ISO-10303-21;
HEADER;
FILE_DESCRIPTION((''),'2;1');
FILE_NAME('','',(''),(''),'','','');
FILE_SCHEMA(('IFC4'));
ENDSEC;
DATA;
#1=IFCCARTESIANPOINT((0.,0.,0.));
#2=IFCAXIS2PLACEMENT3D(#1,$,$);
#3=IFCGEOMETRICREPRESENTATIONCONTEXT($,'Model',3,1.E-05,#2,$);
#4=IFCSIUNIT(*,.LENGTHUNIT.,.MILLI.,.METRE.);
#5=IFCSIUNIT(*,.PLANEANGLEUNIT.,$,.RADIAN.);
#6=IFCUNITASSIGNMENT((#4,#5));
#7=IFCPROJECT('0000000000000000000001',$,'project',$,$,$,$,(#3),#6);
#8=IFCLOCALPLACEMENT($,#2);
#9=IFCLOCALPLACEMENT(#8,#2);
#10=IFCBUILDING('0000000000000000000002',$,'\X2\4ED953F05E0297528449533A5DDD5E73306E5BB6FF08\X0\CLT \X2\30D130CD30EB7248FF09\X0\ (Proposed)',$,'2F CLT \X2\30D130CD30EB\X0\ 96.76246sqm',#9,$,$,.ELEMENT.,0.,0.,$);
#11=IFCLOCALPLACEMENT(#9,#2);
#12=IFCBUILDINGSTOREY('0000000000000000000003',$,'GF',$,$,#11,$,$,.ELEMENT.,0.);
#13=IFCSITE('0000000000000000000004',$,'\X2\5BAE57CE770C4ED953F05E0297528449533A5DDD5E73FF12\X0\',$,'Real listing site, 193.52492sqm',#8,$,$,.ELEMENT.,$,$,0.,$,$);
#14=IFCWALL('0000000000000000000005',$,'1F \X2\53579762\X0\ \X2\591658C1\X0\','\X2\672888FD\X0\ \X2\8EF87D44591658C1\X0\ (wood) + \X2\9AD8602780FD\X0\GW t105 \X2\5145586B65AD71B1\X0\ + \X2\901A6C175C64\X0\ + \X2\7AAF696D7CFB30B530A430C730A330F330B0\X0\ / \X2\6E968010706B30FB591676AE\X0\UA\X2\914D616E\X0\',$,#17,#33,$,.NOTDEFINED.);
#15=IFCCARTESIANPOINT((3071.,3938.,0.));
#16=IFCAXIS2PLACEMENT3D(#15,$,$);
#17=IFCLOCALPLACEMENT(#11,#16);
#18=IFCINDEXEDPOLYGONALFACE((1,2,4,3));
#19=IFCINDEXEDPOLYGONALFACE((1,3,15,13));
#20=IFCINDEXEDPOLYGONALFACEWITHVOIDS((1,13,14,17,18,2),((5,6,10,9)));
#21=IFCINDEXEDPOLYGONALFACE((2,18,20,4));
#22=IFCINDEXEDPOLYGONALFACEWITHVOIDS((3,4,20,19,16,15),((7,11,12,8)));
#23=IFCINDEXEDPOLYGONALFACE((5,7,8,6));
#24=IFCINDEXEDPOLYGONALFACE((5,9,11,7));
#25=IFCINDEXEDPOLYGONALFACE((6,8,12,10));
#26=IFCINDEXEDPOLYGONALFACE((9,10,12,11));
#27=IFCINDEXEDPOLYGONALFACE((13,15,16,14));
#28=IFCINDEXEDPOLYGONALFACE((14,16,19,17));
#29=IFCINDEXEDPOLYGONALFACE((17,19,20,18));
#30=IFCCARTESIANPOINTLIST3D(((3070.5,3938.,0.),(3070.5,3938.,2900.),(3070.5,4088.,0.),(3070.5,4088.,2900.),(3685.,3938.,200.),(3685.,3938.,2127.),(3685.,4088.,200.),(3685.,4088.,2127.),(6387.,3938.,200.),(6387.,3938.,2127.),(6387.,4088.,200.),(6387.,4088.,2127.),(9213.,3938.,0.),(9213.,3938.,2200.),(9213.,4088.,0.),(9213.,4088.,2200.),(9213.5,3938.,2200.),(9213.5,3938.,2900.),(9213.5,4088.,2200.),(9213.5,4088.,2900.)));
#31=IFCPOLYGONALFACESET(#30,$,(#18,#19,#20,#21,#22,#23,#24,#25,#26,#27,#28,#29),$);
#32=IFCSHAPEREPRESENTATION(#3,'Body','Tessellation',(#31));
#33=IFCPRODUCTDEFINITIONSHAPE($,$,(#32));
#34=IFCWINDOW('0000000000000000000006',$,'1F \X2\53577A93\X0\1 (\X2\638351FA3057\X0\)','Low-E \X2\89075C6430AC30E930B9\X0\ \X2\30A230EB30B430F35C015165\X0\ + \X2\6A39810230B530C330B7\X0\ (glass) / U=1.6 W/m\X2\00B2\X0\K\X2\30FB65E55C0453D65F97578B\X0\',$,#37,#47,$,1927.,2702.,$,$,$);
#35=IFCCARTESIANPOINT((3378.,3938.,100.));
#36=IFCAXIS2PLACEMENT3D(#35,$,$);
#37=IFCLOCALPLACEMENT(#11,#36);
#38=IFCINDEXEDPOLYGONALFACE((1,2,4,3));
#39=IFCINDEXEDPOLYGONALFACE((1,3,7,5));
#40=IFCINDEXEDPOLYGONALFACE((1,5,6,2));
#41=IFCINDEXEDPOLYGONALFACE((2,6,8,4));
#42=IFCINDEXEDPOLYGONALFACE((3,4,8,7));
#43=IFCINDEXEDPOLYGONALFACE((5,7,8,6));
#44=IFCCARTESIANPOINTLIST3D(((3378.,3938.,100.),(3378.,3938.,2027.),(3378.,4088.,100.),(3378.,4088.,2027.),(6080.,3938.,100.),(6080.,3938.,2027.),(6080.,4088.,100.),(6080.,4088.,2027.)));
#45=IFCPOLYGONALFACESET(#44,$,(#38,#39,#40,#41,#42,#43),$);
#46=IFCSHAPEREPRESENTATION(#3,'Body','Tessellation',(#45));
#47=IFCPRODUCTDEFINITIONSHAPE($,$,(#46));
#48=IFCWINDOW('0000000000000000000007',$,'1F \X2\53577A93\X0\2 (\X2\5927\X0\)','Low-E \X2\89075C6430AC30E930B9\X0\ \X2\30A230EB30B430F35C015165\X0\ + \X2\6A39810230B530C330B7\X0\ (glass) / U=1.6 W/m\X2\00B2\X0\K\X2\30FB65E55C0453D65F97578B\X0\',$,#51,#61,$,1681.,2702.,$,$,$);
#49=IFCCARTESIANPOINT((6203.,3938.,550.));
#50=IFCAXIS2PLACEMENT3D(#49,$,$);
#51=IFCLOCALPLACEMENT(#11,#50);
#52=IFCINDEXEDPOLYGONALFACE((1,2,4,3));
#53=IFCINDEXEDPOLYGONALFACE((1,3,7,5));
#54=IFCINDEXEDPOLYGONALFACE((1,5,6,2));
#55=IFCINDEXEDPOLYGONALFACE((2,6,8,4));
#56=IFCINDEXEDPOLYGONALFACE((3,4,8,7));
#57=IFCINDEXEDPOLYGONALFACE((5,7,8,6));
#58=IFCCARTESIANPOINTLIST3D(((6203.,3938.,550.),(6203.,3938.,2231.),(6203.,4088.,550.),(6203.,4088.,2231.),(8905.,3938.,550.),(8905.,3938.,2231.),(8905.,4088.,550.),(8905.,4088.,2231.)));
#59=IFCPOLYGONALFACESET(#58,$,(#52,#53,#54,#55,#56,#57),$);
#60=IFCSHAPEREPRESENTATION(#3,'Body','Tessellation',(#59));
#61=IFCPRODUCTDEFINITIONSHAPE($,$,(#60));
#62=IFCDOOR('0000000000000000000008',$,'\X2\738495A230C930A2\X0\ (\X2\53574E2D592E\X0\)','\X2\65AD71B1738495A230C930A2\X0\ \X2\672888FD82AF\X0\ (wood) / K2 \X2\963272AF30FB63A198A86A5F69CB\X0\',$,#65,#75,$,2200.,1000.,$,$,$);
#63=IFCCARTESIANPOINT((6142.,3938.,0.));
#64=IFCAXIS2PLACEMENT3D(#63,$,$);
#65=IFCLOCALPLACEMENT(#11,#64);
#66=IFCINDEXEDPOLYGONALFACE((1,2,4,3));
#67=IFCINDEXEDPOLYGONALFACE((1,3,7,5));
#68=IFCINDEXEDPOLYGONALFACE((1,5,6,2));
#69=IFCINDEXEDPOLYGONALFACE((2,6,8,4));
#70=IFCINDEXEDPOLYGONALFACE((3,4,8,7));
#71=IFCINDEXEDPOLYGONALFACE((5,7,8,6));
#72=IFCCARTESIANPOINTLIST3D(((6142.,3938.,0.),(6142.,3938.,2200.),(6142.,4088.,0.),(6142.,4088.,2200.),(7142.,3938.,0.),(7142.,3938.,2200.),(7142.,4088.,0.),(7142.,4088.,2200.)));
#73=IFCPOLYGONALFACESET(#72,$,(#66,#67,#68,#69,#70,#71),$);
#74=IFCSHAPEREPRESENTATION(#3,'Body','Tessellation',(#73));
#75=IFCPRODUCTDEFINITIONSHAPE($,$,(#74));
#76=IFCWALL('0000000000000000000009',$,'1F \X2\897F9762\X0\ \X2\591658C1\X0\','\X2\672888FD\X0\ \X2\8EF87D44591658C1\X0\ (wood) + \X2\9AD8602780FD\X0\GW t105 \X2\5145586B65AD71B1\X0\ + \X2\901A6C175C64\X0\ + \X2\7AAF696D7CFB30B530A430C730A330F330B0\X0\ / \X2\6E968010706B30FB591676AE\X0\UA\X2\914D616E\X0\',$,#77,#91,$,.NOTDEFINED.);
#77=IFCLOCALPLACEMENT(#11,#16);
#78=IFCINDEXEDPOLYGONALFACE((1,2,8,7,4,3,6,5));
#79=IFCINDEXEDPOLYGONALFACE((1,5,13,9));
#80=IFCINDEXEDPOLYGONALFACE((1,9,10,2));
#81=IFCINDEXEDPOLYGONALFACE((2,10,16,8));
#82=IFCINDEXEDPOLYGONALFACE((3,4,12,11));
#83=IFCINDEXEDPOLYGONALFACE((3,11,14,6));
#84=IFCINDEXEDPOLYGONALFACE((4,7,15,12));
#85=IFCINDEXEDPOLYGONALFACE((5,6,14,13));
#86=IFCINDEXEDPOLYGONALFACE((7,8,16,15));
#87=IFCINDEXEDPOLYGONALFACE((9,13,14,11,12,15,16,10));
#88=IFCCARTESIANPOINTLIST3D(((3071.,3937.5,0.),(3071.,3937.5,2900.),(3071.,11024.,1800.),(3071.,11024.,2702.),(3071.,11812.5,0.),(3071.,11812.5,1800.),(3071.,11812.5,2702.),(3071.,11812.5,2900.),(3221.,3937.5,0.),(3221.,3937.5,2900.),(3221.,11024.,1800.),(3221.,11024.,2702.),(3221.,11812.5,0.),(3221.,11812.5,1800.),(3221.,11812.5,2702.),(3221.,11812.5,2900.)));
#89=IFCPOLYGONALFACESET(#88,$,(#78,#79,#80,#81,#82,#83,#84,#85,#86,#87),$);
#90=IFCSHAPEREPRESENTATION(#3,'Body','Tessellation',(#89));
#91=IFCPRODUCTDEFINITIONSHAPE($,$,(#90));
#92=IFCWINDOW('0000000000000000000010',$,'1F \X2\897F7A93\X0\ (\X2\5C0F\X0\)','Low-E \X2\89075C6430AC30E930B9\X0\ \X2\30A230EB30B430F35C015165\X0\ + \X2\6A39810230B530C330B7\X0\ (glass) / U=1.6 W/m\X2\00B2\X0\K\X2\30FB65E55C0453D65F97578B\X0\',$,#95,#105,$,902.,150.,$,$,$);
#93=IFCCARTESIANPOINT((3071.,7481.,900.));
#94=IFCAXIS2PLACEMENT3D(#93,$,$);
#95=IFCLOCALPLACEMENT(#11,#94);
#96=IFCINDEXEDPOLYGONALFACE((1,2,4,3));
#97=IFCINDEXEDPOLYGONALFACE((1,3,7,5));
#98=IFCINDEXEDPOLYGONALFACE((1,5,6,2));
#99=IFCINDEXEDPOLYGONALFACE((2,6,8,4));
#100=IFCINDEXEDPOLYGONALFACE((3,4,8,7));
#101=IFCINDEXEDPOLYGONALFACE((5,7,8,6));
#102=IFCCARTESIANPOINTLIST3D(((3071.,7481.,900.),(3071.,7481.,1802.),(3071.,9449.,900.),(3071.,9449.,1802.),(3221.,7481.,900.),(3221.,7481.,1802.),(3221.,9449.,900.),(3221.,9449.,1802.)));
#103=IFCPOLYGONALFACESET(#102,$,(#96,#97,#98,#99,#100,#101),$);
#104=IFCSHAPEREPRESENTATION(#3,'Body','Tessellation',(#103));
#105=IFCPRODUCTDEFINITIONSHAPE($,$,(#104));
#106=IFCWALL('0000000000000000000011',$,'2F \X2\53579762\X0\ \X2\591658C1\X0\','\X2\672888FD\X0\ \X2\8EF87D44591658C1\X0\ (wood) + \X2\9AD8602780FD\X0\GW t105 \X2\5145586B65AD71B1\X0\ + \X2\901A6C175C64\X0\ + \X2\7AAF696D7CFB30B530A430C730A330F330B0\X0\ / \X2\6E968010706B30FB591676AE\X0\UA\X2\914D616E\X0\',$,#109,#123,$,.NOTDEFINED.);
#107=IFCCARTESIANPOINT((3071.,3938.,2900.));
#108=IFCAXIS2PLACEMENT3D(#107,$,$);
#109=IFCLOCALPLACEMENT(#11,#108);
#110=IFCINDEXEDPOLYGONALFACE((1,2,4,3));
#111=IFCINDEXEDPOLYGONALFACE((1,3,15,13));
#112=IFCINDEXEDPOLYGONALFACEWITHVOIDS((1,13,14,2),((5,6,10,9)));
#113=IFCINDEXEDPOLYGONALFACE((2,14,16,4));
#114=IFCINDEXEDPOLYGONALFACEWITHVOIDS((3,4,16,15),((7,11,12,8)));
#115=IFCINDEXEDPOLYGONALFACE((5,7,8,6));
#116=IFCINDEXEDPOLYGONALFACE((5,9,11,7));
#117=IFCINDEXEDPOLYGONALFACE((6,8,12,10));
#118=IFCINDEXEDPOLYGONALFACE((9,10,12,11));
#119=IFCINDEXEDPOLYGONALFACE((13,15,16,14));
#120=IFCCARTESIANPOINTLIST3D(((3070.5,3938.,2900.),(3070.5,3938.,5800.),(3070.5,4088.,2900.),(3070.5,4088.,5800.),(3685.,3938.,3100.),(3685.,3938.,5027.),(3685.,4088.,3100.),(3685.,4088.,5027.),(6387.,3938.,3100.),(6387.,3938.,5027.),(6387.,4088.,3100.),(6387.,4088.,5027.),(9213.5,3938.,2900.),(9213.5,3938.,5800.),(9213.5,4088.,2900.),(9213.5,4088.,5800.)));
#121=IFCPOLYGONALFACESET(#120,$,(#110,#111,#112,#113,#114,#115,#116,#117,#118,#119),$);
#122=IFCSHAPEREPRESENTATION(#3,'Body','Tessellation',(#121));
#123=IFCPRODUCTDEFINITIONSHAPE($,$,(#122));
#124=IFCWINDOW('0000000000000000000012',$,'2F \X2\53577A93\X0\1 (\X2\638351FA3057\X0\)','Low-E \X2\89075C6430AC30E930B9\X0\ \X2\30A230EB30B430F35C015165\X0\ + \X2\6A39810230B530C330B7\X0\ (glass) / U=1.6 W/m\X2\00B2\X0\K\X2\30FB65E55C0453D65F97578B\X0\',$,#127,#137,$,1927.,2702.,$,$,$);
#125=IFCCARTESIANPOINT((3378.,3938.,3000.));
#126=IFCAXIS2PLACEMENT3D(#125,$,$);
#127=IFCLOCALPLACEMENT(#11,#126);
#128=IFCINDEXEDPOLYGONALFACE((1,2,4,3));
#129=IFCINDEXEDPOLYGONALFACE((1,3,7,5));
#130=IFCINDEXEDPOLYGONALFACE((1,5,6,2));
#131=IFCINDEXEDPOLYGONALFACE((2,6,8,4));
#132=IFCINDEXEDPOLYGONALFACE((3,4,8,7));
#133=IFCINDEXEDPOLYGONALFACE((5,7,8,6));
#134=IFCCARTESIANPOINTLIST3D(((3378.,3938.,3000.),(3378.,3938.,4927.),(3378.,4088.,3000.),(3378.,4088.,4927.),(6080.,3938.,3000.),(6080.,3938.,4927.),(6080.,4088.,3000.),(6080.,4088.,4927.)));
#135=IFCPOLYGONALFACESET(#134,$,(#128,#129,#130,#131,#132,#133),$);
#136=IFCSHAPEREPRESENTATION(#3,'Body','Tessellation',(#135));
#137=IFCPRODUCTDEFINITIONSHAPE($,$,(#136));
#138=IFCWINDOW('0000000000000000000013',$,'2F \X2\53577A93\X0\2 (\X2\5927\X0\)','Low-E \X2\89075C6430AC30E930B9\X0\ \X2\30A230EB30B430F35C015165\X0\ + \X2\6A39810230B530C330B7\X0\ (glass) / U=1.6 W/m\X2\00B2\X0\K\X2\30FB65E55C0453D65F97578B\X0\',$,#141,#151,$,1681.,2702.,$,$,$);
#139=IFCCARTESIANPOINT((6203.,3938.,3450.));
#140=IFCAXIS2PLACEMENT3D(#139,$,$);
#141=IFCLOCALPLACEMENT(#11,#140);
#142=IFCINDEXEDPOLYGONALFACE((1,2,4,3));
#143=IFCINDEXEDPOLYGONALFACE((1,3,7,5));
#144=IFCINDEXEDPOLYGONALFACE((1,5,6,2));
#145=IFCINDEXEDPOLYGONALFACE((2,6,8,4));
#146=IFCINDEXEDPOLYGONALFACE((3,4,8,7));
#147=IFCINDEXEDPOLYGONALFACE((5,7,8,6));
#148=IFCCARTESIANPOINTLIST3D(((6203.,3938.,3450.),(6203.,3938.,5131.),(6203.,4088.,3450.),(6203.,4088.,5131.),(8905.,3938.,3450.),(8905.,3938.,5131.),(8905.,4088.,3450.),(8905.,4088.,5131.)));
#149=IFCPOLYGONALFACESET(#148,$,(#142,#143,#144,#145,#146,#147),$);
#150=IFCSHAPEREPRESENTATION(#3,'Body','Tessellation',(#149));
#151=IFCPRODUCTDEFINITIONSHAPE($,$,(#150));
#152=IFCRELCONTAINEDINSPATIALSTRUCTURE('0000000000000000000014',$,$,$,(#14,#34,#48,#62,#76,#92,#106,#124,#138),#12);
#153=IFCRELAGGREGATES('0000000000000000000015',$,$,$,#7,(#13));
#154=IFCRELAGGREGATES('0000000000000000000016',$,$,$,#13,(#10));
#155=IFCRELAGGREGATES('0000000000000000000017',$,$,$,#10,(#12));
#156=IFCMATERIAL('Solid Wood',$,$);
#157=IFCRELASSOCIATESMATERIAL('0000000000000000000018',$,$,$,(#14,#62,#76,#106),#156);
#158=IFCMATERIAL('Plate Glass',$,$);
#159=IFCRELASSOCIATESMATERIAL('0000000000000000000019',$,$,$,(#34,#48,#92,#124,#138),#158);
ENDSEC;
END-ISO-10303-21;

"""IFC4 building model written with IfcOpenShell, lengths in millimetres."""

from ifc_helpers import new_model, si_unit, frame, frame_2d, origin, place, context, project, spatial, rectangle, extrude, material, element, fill, save


model = new_model("IFC4")

# Units and contexts
model_context = context("Model", 3, precision=1e-05, world=origin())
ifc_project = project(units=[si_unit("LENGTHUNIT", "METRE", prefix="MILLI"), si_unit("PLANEANGLEUNIT", "RADIAN")], contexts=[model_context])

# Site, building, storey
site_placement = place(None, origin())
site = spatial("IfcSite", under=ifc_project, at=site_placement, Name="宮城県仙台市青葉区川平２", ObjectType="Real listing site, 193.52492sqm", CompositionType="ELEMENT", RefElevation=0.0)
building_placement = place(site_placement, origin())
building = spatial("IfcBuilding", under=site, at=building_placement, Name="仙台市青葉区川平の家（CLT パネル版） (Proposed)", ObjectType="2F CLT パネル 96.76246sqm", CompositionType="ELEMENT", ElevationOfRefHeight=0.0, ElevationOfTerrain=0.0)
storey_placement = place(building_placement, origin())
storey = spatial("IfcBuildingStorey", under=building, at=storey_placement, Name="GF", CompositionType="ELEMENT", Elevation=0.0)

# Shared definitions
ifc_material_1 = material(Name="Solid Wood")

# Wall, openings, windows, door
wall_1_placement = place(storey_placement, frame((3071.0, 3938.0, 0.0)))
wall_1 = element("IfcWall", 1, at=wall_1_placement, inside=storey, material=ifc_material_1, Name="1F 南面 外壁", Description="木製 軸組外壁 (wood) + 高性能GW t105 充填断熱 + 通気層 + 窯業系サイディング / 準耐火・外皮UA配慮", PredefinedType="NOTDEFINED", context=model_context, shape_type="SweptSolid", body=[
    extrude(rectangle(XDim=6143.0, YDim=150.0, at=frame_2d((3071.0, 75.0))), frame((3071.0, 3938.0, 0.0)), (0.0, 0.0, 1.0), 2900.0),
])
opening_1_placement = place(storey_placement, frame((3378.0, 3938.0, 100.0)))
opening_1 = element("IfcOpeningElement", 2, at=opening_1_placement, cuts=wall_1, PredefinedType="NOTDEFINED", context=model_context, shape_type="SweptSolid", body=[
    extrude(rectangle(XDim=2702.0, YDim=150.0, at=frame_2d((1351.0, 75.0))), frame((3378.0, 3938.0, 100.0)), (0.0, 0.0, 1.0), 1927.0),
])
opening_2_placement = place(storey_placement, frame((6203.0, 3938.0, 550.0)))
opening_2 = element("IfcOpeningElement", 3, at=opening_2_placement, cuts=wall_1, PredefinedType="NOTDEFINED", context=model_context, shape_type="SweptSolid", body=[
    extrude(rectangle(XDim=2702.0, YDim=150.0, at=frame_2d((1351.0, 75.0))), frame((6203.0, 3938.0, 550.0)), (0.0, 0.0, 1.0), 1681.0),
])
opening_3_placement = place(storey_placement, frame((6142.0, 3938.0, 0.0)))
opening_3 = element("IfcOpeningElement", 4, at=opening_3_placement, cuts=wall_1, PredefinedType="NOTDEFINED", context=model_context, shape_type="SweptSolid", body=[
    extrude(rectangle(XDim=1000.0, YDim=150.0, at=frame_2d((500.0, 75.0))), frame((6142.0, 3938.0, 0.0)), (0.0, 0.0, 1.0), 2200.0),
])
ifc_material_2 = material(Name="Plate Glass")
window_1_placement = place(storey_placement, frame((3378.0, 3938.0, 100.0)))
window_1 = element("IfcWindow", 5, at=window_1_placement, inside=storey, material=ifc_material_2, Name="1F 南窓1 (掃出し)", Description="Low-E 複層ガラス アルゴン封入 + 樹脂サッシ (glass) / U=1.6 W/m²K・日射取得型", OverallHeight=1927.0, OverallWidth=2702.0, context=model_context, shape_type="SweptSolid", body=[
    extrude(rectangle(XDim=2702.0, YDim=150.0, at=frame_2d((1351.0, 75.0))), frame((3378.0, 3938.0, 100.0)), (0.0, 0.0, 1.0), 1927.0),
])
fill(opening_1, window_1)
window_2_placement = place(storey_placement, frame((6203.0, 3938.0, 550.0)))
window_2 = element("IfcWindow", 6, at=window_2_placement, inside=storey, material=ifc_material_2, Name="1F 南窓2 (大)", Description="Low-E 複層ガラス アルゴン封入 + 樹脂サッシ (glass) / U=1.6 W/m²K・日射取得型", OverallHeight=1681.0, OverallWidth=2702.0, context=model_context, shape_type="SweptSolid", body=[
    extrude(rectangle(XDim=2702.0, YDim=150.0, at=frame_2d((1351.0, 75.0))), frame((6203.0, 3938.0, 550.0)), (0.0, 0.0, 1.0), 1681.0),
])
fill(opening_2, window_2)
door_placement = place(storey_placement, frame((6142.0, 3938.0, 0.0)))
door = element("IfcDoor", 7, at=door_placement, inside=storey, material=ifc_material_1, Name="玄関ドア (南中央)", Description="断熱玄関ドア 木製芯 (wood) / K2 防犯・採風機構", OverallHeight=2200.0, OverallWidth=1000.0, context=model_context, shape_type="SweptSolid", body=[
    extrude(rectangle(XDim=1000.0, YDim=150.0, at=frame_2d((500.0, 75.0))), frame((6142.0, 3938.0, 0.0)), (0.0, 0.0, 1.0), 2200.0),
])
fill(opening_3, door)

# Wall, opening, window
wall_2_placement = place(storey_placement, frame((3071.0, 3938.0, 0.0)))
wall_2 = element("IfcWall", 8, at=wall_2_placement, inside=storey, material=ifc_material_1, Name="1F 西面 外壁", Description="木製 軸組外壁 (wood) + 高性能GW t105 充填断熱 + 通気層 + 窯業系サイディング / 準耐火・外皮UA配慮", PredefinedType="NOTDEFINED", context=model_context, shape_type="SweptSolid", body=[
    extrude(rectangle(XDim=150.0, YDim=7875.0, at=frame_2d((75.0, 3937.0))), frame((3071.0, 3938.0, 0.0)), (0.0, 0.0, 1.0), 2900.0),
])
opening_4_placement = place(storey_placement, frame((3071.0, 7481.0, 900.0)))
opening_4 = element("IfcOpeningElement", 9, at=opening_4_placement, cuts=wall_2, PredefinedType="NOTDEFINED", context=model_context, shape_type="SweptSolid", body=[
    extrude(rectangle(XDim=150.0, YDim=1968.0, at=frame_2d((75.0, 984.0))), frame((3071.0, 7481.0, 900.0)), (0.0, 0.0, 1.0), 902.0),
])
window_3_placement = place(storey_placement, frame((3071.0, 7481.0, 900.0)))
window_3 = element("IfcWindow", 10, at=window_3_placement, inside=storey, material=ifc_material_2, Name="1F 西窓 (小)", Description="Low-E 複層ガラス アルゴン封入 + 樹脂サッシ (glass) / U=1.6 W/m²K・日射取得型", OverallHeight=902.0, OverallWidth=150.0, context=model_context, shape_type="SweptSolid", body=[
    extrude(rectangle(XDim=150.0, YDim=1968.0, at=frame_2d((75.0, 984.0))), frame((3071.0, 7481.0, 900.0)), (0.0, 0.0, 1.0), 902.0),
])
fill(opening_4, window_3)

# Wall, openings, windows
wall_3_placement = place(storey_placement, frame((3071.0, 3938.0, 2900.0)))
wall_3 = element("IfcWall", 11, at=wall_3_placement, inside=storey, material=ifc_material_1, Name="2F 南面 外壁", Description="木製 軸組外壁 (wood) + 高性能GW t105 充填断熱 + 通気層 + 窯業系サイディング / 準耐火・外皮UA配慮", PredefinedType="NOTDEFINED", context=model_context, shape_type="SweptSolid", body=[
    extrude(rectangle(XDim=6143.0, YDim=150.0, at=frame_2d((3071.0, 75.0))), frame((3071.0, 3938.0, 2900.0)), (0.0, 0.0, 1.0), 2900.0),
])
opening_5_placement = place(storey_placement, frame((3378.0, 3938.0, 3000.0)))
opening_5 = element("IfcOpeningElement", 12, at=opening_5_placement, cuts=wall_3, PredefinedType="NOTDEFINED", context=model_context, shape_type="SweptSolid", body=[
    extrude(rectangle(XDim=2702.0, YDim=150.0, at=frame_2d((1351.0, 75.0))), frame((3378.0, 3938.0, 3000.0)), (0.0, 0.0, 1.0), 1927.0),
])
opening_6_placement = place(storey_placement, frame((6203.0, 3938.0, 3450.0)))
opening_6 = element("IfcOpeningElement", 13, at=opening_6_placement, cuts=wall_3, PredefinedType="NOTDEFINED", context=model_context, shape_type="SweptSolid", body=[
    extrude(rectangle(XDim=2702.0, YDim=150.0, at=frame_2d((1351.0, 75.0))), frame((6203.0, 3938.0, 3450.0)), (0.0, 0.0, 1.0), 1681.0),
])
window_4_placement = place(storey_placement, frame((3378.0, 3938.0, 3000.0)))
window_4 = element("IfcWindow", 14, at=window_4_placement, inside=storey, material=ifc_material_2, Name="2F 南窓1 (掃出し)", Description="Low-E 複層ガラス アルゴン封入 + 樹脂サッシ (glass) / U=1.6 W/m²K・日射取得型", OverallHeight=1927.0, OverallWidth=2702.0, context=model_context, shape_type="SweptSolid", body=[
    extrude(rectangle(XDim=2702.0, YDim=150.0, at=frame_2d((1351.0, 75.0))), frame((3378.0, 3938.0, 3000.0)), (0.0, 0.0, 1.0), 1927.0),
])
fill(opening_5, window_4)
window_5_placement = place(storey_placement, frame((6203.0, 3938.0, 3450.0)))
window_5 = element("IfcWindow", 15, at=window_5_placement, inside=storey, material=ifc_material_2, Name="2F 南窓2 (大)", Description="Low-E 複層ガラス アルゴン封入 + 樹脂サッシ (glass) / U=1.6 W/m²K・日射取得型", OverallHeight=1681.0, OverallWidth=2702.0, context=model_context, shape_type="SweptSolid", body=[
    extrude(rectangle(XDim=2702.0, YDim=150.0, at=frame_2d((1351.0, 75.0))), frame((6203.0, 3938.0, 3450.0)), (0.0, 0.0, 1.0), 1681.0),
])
fill(opening_6, window_5)

save(model, "model.ifc")
